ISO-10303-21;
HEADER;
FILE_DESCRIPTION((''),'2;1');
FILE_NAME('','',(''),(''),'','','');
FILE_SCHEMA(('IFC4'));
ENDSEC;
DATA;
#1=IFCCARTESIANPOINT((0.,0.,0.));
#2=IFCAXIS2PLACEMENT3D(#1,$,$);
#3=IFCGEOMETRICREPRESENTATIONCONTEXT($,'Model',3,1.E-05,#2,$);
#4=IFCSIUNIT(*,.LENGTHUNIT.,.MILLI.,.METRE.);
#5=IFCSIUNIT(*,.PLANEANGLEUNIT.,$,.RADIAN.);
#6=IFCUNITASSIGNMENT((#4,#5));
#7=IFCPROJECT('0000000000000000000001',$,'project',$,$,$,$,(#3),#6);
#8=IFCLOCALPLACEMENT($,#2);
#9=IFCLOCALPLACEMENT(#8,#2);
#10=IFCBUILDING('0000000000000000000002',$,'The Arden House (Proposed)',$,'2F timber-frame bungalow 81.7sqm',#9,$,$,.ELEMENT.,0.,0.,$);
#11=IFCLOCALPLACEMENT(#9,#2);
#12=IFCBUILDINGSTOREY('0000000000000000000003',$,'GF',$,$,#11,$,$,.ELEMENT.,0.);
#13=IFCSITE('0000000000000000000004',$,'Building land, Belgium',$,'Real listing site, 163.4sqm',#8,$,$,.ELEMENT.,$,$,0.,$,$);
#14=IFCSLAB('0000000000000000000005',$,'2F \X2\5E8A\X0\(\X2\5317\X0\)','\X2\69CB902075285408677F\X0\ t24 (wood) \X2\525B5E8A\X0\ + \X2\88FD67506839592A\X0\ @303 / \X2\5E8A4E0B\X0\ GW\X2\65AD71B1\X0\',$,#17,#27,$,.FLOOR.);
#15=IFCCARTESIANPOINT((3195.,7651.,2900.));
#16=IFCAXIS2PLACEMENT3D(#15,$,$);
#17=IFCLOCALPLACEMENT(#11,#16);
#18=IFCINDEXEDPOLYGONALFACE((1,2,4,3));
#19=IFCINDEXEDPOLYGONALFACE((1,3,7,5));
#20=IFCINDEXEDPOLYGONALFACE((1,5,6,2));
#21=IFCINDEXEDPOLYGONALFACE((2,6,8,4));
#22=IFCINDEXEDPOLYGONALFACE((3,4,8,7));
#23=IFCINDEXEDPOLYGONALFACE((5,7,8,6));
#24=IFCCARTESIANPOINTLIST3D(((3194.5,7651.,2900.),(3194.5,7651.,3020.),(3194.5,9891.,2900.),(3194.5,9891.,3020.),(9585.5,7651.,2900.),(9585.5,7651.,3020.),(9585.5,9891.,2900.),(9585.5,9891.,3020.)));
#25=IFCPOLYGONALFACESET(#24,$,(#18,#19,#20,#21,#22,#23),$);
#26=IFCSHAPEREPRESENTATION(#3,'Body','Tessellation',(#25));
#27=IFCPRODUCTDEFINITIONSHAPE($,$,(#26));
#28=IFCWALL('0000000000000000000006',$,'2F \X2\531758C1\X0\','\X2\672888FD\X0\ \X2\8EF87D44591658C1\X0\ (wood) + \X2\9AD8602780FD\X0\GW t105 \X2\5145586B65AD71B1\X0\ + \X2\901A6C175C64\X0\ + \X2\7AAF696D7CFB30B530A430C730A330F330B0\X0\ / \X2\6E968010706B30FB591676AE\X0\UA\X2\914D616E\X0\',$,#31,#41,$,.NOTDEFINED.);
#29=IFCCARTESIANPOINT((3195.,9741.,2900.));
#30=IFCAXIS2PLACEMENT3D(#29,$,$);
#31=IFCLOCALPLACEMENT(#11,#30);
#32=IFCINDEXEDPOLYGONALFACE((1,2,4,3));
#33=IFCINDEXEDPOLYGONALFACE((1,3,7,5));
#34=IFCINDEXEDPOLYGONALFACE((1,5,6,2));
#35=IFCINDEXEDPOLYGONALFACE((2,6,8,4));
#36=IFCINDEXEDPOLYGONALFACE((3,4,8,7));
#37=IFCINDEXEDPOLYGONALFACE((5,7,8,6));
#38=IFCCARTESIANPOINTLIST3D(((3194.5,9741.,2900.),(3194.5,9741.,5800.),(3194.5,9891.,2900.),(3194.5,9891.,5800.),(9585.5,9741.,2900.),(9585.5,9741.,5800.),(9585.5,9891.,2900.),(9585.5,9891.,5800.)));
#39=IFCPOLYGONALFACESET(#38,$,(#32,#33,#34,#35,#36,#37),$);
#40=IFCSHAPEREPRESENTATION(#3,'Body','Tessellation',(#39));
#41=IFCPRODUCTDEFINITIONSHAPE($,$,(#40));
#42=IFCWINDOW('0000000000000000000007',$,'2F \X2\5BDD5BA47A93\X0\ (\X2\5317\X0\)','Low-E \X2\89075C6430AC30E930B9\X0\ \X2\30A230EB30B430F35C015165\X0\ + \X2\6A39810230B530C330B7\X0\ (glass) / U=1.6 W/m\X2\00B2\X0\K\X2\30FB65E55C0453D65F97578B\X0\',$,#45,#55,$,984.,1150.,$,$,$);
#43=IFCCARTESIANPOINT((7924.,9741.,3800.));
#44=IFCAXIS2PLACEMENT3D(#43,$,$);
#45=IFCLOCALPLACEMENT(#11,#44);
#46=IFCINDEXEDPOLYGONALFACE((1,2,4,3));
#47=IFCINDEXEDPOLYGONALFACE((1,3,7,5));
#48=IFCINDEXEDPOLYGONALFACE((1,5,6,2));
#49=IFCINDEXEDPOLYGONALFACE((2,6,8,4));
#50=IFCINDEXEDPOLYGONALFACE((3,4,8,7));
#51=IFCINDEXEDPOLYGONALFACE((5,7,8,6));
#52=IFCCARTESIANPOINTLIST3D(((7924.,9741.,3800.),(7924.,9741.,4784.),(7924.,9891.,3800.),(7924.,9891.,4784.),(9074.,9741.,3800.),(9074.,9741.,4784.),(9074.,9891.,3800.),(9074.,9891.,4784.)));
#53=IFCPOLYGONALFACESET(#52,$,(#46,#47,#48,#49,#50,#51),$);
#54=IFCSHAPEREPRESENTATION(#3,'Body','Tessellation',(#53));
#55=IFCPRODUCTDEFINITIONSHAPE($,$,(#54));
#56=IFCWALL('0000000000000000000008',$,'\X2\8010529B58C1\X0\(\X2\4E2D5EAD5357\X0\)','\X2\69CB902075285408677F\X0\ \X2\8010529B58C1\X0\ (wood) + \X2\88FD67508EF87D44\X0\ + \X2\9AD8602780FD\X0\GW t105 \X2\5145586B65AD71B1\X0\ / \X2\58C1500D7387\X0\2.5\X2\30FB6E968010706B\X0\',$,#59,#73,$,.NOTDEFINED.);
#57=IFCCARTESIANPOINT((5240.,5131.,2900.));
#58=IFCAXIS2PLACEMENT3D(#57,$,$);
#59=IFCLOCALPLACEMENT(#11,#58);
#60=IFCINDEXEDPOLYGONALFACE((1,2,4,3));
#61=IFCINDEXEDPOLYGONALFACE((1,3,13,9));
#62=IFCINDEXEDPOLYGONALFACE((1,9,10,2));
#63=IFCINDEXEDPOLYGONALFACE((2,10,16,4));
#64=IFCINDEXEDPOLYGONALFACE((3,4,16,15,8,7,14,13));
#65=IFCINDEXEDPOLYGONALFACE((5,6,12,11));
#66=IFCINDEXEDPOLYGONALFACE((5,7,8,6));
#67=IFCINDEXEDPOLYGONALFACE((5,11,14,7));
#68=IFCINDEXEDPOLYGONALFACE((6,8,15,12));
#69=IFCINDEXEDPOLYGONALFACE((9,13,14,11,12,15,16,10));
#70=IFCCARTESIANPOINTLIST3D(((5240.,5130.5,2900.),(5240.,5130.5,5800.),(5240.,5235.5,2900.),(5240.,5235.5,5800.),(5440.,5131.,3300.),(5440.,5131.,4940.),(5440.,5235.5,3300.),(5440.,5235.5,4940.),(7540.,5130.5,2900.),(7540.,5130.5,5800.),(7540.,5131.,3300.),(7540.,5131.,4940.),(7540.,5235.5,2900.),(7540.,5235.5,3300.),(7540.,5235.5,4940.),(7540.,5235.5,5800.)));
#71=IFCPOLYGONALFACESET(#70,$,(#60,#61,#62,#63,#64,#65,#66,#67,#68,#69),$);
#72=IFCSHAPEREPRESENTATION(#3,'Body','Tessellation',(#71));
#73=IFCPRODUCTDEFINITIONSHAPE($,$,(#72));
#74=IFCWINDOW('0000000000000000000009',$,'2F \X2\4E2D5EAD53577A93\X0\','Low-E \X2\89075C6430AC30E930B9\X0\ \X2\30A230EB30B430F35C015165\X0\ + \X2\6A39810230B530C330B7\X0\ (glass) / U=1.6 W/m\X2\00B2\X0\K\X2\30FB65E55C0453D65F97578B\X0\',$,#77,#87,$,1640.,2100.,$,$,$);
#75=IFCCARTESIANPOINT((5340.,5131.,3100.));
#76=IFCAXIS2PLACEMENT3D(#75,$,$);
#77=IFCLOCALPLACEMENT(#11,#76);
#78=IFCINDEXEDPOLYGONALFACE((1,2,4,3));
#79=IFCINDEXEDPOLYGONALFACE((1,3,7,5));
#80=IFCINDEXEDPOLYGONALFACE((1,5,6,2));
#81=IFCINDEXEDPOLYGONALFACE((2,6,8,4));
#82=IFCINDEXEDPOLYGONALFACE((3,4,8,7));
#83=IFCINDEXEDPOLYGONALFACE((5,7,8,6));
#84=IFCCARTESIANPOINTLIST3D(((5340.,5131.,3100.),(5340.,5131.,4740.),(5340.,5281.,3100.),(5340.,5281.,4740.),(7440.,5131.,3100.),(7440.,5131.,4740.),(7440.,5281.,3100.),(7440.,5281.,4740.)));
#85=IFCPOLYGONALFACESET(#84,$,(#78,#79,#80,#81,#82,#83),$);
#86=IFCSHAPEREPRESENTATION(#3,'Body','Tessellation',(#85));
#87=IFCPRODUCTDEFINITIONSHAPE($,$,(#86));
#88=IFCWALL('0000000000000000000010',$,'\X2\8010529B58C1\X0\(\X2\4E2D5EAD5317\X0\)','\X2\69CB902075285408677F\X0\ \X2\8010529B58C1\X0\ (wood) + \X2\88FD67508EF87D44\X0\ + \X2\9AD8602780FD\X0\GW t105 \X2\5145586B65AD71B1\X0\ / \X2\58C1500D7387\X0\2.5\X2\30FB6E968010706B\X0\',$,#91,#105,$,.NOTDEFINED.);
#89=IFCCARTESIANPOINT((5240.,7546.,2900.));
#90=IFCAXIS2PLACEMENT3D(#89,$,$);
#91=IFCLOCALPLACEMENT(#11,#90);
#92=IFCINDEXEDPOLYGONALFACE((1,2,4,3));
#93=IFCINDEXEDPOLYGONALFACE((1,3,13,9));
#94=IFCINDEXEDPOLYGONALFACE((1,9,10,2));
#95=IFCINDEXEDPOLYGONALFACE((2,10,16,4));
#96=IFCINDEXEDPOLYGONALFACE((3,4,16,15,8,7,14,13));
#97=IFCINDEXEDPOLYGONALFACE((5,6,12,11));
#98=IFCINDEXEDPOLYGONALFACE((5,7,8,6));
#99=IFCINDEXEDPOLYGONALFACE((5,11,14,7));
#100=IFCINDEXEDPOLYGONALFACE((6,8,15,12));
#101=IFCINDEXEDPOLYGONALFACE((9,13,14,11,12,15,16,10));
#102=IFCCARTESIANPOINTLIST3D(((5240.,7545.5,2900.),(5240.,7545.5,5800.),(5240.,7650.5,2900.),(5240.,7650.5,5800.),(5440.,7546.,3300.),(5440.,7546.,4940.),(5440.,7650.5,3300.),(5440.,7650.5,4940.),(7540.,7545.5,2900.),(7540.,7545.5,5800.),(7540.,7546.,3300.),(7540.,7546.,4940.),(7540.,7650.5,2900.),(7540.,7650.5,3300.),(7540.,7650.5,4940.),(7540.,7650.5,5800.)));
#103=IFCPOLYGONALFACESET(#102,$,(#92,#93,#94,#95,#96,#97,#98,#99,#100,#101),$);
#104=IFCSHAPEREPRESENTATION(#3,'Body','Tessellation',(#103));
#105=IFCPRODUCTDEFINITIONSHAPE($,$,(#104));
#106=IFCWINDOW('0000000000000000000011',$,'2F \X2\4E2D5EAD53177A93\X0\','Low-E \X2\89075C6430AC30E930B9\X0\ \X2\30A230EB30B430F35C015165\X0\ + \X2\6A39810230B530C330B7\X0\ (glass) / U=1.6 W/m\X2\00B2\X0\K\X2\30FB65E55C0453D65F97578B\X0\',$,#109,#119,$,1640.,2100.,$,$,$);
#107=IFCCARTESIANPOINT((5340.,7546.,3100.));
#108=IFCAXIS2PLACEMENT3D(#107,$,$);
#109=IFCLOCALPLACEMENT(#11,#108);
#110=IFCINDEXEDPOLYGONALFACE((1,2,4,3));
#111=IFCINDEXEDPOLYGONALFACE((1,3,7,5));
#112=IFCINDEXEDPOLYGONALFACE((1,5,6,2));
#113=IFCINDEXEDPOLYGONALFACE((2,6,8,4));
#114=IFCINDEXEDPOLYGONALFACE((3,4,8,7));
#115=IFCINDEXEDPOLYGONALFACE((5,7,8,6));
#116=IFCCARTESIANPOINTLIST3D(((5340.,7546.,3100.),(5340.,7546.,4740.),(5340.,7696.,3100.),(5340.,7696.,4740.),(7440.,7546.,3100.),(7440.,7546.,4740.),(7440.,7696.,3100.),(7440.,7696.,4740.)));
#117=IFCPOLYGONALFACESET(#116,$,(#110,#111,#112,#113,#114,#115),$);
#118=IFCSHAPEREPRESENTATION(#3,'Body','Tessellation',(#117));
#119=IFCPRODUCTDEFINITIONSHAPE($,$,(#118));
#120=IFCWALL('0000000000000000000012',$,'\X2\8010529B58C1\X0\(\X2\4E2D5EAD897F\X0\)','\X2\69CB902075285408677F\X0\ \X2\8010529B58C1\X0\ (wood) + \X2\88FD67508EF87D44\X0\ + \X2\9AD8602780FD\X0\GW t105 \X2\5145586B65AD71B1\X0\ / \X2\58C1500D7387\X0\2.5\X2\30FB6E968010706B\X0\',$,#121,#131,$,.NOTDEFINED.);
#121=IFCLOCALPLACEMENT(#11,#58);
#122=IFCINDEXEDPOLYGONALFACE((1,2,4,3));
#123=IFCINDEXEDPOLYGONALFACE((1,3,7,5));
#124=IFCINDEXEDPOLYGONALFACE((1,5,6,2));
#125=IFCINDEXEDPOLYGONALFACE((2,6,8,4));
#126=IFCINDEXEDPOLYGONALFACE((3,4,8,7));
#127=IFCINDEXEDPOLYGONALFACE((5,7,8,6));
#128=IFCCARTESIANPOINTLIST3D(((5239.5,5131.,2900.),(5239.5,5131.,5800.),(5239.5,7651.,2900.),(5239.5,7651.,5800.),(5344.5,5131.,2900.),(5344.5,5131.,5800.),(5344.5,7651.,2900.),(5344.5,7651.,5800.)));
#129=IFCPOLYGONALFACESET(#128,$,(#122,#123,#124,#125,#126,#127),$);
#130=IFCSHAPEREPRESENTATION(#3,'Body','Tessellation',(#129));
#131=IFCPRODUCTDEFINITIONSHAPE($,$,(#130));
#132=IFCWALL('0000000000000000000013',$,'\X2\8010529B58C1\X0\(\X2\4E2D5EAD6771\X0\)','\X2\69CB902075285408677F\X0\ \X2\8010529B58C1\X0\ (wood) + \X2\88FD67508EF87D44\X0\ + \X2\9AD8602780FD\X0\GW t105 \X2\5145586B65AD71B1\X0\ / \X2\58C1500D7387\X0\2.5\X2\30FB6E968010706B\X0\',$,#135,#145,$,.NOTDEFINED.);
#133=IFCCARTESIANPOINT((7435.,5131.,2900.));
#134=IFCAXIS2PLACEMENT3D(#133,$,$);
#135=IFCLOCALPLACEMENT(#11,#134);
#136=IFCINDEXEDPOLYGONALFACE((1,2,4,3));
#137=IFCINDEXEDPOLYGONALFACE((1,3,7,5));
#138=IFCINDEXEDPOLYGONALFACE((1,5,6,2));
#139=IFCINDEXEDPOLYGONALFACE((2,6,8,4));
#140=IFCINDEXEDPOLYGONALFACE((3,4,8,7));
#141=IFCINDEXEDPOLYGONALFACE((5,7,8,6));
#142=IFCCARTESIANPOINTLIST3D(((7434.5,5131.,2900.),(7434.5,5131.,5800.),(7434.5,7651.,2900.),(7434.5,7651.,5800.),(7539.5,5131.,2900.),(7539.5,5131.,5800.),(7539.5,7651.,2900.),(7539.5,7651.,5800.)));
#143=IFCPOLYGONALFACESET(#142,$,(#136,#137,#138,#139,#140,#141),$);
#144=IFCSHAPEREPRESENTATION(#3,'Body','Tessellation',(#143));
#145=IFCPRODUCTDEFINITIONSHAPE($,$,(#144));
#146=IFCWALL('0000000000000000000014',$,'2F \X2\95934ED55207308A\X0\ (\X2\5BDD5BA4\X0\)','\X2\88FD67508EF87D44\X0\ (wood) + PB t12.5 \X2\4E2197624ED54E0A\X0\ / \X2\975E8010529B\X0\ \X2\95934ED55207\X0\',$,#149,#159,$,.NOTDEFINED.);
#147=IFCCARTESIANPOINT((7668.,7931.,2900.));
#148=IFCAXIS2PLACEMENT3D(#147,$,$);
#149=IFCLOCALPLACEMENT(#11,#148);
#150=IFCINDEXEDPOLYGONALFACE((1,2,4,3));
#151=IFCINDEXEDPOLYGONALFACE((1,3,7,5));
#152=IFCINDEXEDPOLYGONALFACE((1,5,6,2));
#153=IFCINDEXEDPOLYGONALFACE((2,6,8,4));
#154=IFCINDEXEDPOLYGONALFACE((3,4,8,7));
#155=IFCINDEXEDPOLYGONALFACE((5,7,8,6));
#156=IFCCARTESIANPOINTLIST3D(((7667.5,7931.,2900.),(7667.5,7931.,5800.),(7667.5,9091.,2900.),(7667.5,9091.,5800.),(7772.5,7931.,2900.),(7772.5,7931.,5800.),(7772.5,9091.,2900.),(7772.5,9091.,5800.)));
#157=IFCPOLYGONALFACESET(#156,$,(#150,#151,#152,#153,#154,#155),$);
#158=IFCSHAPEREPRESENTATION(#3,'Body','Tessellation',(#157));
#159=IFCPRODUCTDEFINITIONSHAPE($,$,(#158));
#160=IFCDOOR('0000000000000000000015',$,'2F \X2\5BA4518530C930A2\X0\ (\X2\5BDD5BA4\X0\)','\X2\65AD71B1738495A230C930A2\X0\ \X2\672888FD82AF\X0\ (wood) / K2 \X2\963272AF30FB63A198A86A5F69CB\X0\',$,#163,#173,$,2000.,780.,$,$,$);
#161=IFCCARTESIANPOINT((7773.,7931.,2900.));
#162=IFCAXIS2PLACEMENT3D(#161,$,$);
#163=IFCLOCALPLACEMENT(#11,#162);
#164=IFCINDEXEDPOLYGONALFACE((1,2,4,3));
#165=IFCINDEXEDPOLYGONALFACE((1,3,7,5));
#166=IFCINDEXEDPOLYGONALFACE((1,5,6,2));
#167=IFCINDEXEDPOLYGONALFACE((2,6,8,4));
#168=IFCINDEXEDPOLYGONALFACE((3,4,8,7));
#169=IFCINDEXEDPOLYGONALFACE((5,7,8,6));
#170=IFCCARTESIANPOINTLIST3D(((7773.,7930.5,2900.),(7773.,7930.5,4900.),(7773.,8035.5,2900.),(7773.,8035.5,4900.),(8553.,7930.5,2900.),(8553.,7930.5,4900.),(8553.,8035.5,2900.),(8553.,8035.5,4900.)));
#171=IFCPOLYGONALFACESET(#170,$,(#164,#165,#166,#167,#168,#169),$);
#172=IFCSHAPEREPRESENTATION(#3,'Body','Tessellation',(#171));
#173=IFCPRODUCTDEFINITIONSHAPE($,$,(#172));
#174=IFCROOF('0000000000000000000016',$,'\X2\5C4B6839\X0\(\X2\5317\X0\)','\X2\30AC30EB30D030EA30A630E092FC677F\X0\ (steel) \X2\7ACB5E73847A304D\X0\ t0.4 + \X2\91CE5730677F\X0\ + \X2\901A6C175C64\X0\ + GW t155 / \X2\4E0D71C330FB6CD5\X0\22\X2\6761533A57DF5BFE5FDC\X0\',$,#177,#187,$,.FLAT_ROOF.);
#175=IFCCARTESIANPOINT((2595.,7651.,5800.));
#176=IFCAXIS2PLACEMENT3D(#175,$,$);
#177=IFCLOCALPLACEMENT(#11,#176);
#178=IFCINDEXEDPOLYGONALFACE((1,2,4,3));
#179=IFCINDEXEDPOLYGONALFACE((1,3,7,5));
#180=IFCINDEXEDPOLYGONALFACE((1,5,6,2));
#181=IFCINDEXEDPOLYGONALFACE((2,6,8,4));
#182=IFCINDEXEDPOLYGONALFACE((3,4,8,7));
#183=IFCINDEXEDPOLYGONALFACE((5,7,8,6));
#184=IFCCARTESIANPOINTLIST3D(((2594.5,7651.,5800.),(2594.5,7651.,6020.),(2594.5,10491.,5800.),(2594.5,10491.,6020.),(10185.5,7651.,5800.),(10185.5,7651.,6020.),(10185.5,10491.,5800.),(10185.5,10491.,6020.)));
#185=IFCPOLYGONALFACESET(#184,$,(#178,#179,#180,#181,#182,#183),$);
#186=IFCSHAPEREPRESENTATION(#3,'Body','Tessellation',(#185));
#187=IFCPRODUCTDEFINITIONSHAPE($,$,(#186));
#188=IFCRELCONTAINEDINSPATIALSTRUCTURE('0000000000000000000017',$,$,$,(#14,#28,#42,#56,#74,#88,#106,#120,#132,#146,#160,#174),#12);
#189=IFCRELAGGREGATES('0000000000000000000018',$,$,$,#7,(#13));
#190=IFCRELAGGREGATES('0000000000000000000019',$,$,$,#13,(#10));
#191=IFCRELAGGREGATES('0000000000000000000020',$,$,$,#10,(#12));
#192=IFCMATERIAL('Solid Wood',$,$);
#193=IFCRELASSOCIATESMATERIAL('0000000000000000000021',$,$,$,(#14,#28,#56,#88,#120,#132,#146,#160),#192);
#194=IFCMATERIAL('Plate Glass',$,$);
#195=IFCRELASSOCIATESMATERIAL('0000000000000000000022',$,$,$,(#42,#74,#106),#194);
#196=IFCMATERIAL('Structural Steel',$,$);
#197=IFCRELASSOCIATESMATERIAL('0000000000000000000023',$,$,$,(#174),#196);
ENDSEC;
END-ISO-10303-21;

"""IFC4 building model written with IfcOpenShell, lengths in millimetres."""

from ifc_helpers import new_model, si_unit, frame, frame_2d, origin, place, context, project, spatial, rectangle, extrude, material, element, fill, save


model = new_model("IFC4")

# Units and contexts
model_context = context("Model", 3, precision=1e-05, world=origin())
ifc_project = project(units=[si_unit("LENGTHUNIT", "METRE", prefix="MILLI"), si_unit("PLANEANGLEUNIT", "RADIAN")], contexts=[model_context])

# Site, building, storey
site_placement = place(None, origin())
site = spatial("IfcSite", under=ifc_project, at=site_placement, Name="Building land, Belgium", ObjectType="Real listing site, 163.4sqm", CompositionType="ELEMENT", RefElevation=0.0)
building_placement = place(site_placement, origin())
building = spatial("IfcBuilding", under=site, at=building_placement, Name="The Arden House (Proposed)", ObjectType="2F timber-frame bungalow 81.7sqm", CompositionType="ELEMENT", ElevationOfRefHeight=0.0, ElevationOfTerrain=0.0)
storey_placement = place(building_placement, origin())
storey = spatial("IfcBuildingStorey", under=building, at=storey_placement, Name="GF", CompositionType="ELEMENT", Elevation=0.0)

# Slab
ifc_material_1 = material(Name="Solid Wood")
slab_placement = place(storey_placement, frame((3195.0, 7651.0, 2900.0)))
element("IfcSlab", 1, at=slab_placement, inside=storey, material=ifc_material_1, Name="2F 床(北)", Description="構造用合板 t24 (wood) 剛床 + 製材根太 @303 / 床下 GW断熱", PredefinedType="FLOOR", context=model_context, shape_type="SweptSolid", body=[
    extrude(rectangle(XDim=6391.0, YDim=2240.0, at=frame_2d((3195.0, 1120.0))), frame((3195.0, 7651.0, 2900.0)), (0.0, 0.0, 1.0), 120.0),
])

# Walls, openings, windows
wall_1_placement = place(storey_placement, frame((3195.0, 9741.0, 2900.0)))
wall_1 = element("IfcWall", 2, at=wall_1_placement, inside=storey, material=ifc_material_1, Name="2F 北壁", Description="木製 軸組外壁 (wood) + 高性能GW t105 充填断熱 + 通気層 + 窯業系サイディング / 準耐火・外皮UA配慮", PredefinedType="NOTDEFINED", context=model_context, shape_type="SweptSolid", body=[
    extrude(rectangle(XDim=6391.0, YDim=150.0, at=frame_2d((3195.0, 75.0))), frame((3195.0, 9741.0, 2900.0)), (0.0, 0.0, 1.0), 2900.0),
])
opening_1_placement = place(storey_placement, frame((7924.0, 9741.0, 3800.0)))
opening_1 = element("IfcOpeningElement", 3, at=opening_1_placement, cuts=wall_1, PredefinedType="NOTDEFINED", context=model_context, shape_type="SweptSolid", body=[
    extrude(rectangle(XDim=1150.0, YDim=150.0, at=frame_2d((575.0, 75.0))), frame((7924.0, 9741.0, 3800.0)), (0.0, 0.0, 1.0), 984.0),
])
ifc_material_2 = material(Name="Plate Glass")
window_1_placement = place(storey_placement, frame((7924.0, 9741.0, 3800.0)))
window_1 = element("IfcWindow", 4, at=window_1_placement, inside=storey, material=ifc_material_2, Name="2F 寝室窓 (北)", Description="Low-E 複層ガラス アルゴン封入 + 樹脂サッシ (glass) / U=1.6 W/m²K・日射取得型", OverallHeight=984.0, OverallWidth=1150.0, context=model_context, shape_type="SweptSolid", body=[
    extrude(rectangle(XDim=1150.0, YDim=150.0, at=frame_2d((575.0, 75.0))), frame((7924.0, 9741.0, 3800.0)), (0.0, 0.0, 1.0), 984.0),
])
fill(opening_1, window_1)
wall_2_placement = place(storey_placement, frame((5240.0, 5131.0, 2900.0)))
wall_2 = element("IfcWall", 5, at=wall_2_placement, inside=storey, material=ifc_material_1, Name="耐力壁(中庭南)", Description="構造用合板 耐力壁 (wood) + 製材軸組 + 高性能GW t105 充填断熱 / 壁倍率2.5・準耐火", PredefinedType="NOTDEFINED", context=model_context, shape_type="SweptSolid", body=[
    extrude(rectangle(XDim=2300.0, YDim=105.0, at=frame_2d((1150.0, 52.0))), frame((5240.0, 5131.0, 2900.0)), (0.0, 0.0, 1.0), 2900.0),
])
opening_2_placement = place(storey_placement, frame((5340.0, 5131.0, 3100.0)))
opening_2 = element("IfcOpeningElement", 6, at=opening_2_placement, cuts=wall_2, PredefinedType="NOTDEFINED", context=model_context, shape_type="SweptSolid", body=[
    extrude(rectangle(XDim=2100.0, YDim=150.0, at=frame_2d((1050.0, 75.0))), frame((5340.0, 5131.0, 3100.0)), (0.0, 0.0, 1.0), 1640.0),
])
window_2_placement = place(storey_placement, frame((5340.0, 5131.0, 3100.0)))
window_2 = element("IfcWindow", 7, at=window_2_placement, inside=storey, material=ifc_material_2, Name="2F 中庭南窓", Description="Low-E 複層ガラス アルゴン封入 + 樹脂サッシ (glass) / U=1.6 W/m²K・日射取得型", OverallHeight=1640.0, OverallWidth=2100.0, context=model_context, shape_type="SweptSolid", body=[
    extrude(rectangle(XDim=2100.0, YDim=150.0, at=frame_2d((1050.0, 75.0))), frame((5340.0, 5131.0, 3100.0)), (0.0, 0.0, 1.0), 1640.0),
])
fill(opening_2, window_2)
wall_3_placement = place(storey_placement, frame((5240.0, 7546.0, 2900.0)))
wall_3 = element("IfcWall", 8, at=wall_3_placement, inside=storey, material=ifc_material_1, Name="耐力壁(中庭北)", Description="構造用合板 耐力壁 (wood) + 製材軸組 + 高性能GW t105 充填断熱 / 壁倍率2.5・準耐火", PredefinedType="NOTDEFINED", context=model_context, shape_type="SweptSolid", body=[
    extrude(rectangle(XDim=2300.0, YDim=105.0, at=frame_2d((1150.0, 52.0))), frame((5240.0, 7546.0, 2900.0)), (0.0, 0.0, 1.0), 2900.0),
])
opening_3_placement = place(storey_placement, frame((5340.0, 7546.0, 3100.0)))
opening_3 = element("IfcOpeningElement", 9, at=opening_3_placement, cuts=wall_3, PredefinedType="NOTDEFINED", context=model_context, shape_type="SweptSolid", body=[
    extrude(rectangle(XDim=2100.0, YDim=150.0, at=frame_2d((1050.0, 75.0))), frame((5340.0, 7546.0, 3100.0)), (0.0, 0.0, 1.0), 1640.0),
])
window_3_placement = place(storey_placement, frame((5340.0, 7546.0, 3100.0)))
window_3 = element("IfcWindow", 10, at=window_3_placement, inside=storey, material=ifc_material_2, Name="2F 中庭北窓", Description="Low-E 複層ガラス アルゴン封入 + 樹脂サッシ (glass) / U=1.6 W/m²K・日射取得型", OverallHeight=1640.0, OverallWidth=2100.0, context=model_context, shape_type="SweptSolid", body=[
    extrude(rectangle(XDim=2100.0, YDim=150.0, at=frame_2d((1050.0, 75.0))), frame((5340.0, 7546.0, 3100.0)), (0.0, 0.0, 1.0), 1640.0),
])
fill(opening_3, window_3)

# Walls
wall_4_placement = place(storey_placement, frame((5240.0, 5131.0, 2900.0)))
element("IfcWall", 11, at=wall_4_placement, inside=storey, material=ifc_material_1, Name="耐力壁(中庭西)", Description="構造用合板 耐力壁 (wood) + 製材軸組 + 高性能GW t105 充填断熱 / 壁倍率2.5・準耐火", PredefinedType="NOTDEFINED", context=model_context, shape_type="SweptSolid", body=[
    extrude(rectangle(XDim=105.0, YDim=2520.0, at=frame_2d((52.0, 1260.0))), frame((5240.0, 5131.0, 2900.0)), (0.0, 0.0, 1.0), 2900.0),
])
wall_5_placement = place(storey_placement, frame((7435.0, 5131.0, 2900.0)))
element("IfcWall", 12, at=wall_5_placement, inside=storey, material=ifc_material_1, Name="耐力壁(中庭東)", Description="構造用合板 耐力壁 (wood) + 製材軸組 + 高性能GW t105 充填断熱 / 壁倍率2.5・準耐火", PredefinedType="NOTDEFINED", context=model_context, shape_type="SweptSolid", body=[
    extrude(rectangle(XDim=105.0, YDim=2520.0, at=frame_2d((52.0, 1260.0))), frame((7435.0, 5131.0, 2900.0)), (0.0, 0.0, 1.0), 2900.0),
])
wall_6_placement = place(storey_placement, frame((7668.0, 7931.0, 2900.0)))
element("IfcWall", 13, at=wall_6_placement, inside=storey, material=ifc_material_1, Name="2F 間仕切り (寝室)", Description="製材軸組 (wood) + PB t12.5 両面仕上 / 非耐力 間仕切", PredefinedType="NOTDEFINED", context=model_context, shape_type="SweptSolid", body=[
    extrude(rectangle(XDim=105.0, YDim=1160.0, at=frame_2d((52.0, 580.0))), frame((7668.0, 7931.0, 2900.0)), (0.0, 0.0, 1.0), 2900.0),
])

# Door
door_placement = place(storey_placement, frame((7773.0, 7931.0, 2900.0)))
element("IfcDoor", 14, at=door_placement, inside=storey, material=ifc_material_1, Name="2F 室内ドア (寝室)", Description="断熱玄関ドア 木製芯 (wood) / K2 防犯・採風機構", OverallHeight=2000.0, OverallWidth=780.0, context=model_context, shape_type="SweptSolid", body=[
    extrude(rectangle(XDim=780.0, YDim=105.0, at=frame_2d((390.0, 52.0))), frame((7773.0, 7931.0, 2900.0)), (0.0, 0.0, 1.0), 2000.0),
])

# Roof
ifc_material_3 = material(Name="Structural Steel")
for number, where, name in (
    (15, (2595.0, 7651.0, 5800.0), "屋根(北)"),
):
    element("IfcRoof", number, at=place(storey_placement, frame(where)), inside=storey, material=ifc_material_3, Name=name, Description="ガルバリウム鋼板 (steel) 立平葺き t0.4 + 野地板 + 通気層 + GW t155 / 不燃・法22条区域対応", PredefinedType="FLAT_ROOF", context=model_context, shape_type="SweptSolid", body=[
        extrude(rectangle(XDim=7591.0, YDim=2840.0, at=frame_2d((3795.0, 1420.0))), frame((2595.0, 7651.0, 5800.0)), (0.0, 0.0, 1.0), 220.0),
    ])

save(model, "model.ifc")
